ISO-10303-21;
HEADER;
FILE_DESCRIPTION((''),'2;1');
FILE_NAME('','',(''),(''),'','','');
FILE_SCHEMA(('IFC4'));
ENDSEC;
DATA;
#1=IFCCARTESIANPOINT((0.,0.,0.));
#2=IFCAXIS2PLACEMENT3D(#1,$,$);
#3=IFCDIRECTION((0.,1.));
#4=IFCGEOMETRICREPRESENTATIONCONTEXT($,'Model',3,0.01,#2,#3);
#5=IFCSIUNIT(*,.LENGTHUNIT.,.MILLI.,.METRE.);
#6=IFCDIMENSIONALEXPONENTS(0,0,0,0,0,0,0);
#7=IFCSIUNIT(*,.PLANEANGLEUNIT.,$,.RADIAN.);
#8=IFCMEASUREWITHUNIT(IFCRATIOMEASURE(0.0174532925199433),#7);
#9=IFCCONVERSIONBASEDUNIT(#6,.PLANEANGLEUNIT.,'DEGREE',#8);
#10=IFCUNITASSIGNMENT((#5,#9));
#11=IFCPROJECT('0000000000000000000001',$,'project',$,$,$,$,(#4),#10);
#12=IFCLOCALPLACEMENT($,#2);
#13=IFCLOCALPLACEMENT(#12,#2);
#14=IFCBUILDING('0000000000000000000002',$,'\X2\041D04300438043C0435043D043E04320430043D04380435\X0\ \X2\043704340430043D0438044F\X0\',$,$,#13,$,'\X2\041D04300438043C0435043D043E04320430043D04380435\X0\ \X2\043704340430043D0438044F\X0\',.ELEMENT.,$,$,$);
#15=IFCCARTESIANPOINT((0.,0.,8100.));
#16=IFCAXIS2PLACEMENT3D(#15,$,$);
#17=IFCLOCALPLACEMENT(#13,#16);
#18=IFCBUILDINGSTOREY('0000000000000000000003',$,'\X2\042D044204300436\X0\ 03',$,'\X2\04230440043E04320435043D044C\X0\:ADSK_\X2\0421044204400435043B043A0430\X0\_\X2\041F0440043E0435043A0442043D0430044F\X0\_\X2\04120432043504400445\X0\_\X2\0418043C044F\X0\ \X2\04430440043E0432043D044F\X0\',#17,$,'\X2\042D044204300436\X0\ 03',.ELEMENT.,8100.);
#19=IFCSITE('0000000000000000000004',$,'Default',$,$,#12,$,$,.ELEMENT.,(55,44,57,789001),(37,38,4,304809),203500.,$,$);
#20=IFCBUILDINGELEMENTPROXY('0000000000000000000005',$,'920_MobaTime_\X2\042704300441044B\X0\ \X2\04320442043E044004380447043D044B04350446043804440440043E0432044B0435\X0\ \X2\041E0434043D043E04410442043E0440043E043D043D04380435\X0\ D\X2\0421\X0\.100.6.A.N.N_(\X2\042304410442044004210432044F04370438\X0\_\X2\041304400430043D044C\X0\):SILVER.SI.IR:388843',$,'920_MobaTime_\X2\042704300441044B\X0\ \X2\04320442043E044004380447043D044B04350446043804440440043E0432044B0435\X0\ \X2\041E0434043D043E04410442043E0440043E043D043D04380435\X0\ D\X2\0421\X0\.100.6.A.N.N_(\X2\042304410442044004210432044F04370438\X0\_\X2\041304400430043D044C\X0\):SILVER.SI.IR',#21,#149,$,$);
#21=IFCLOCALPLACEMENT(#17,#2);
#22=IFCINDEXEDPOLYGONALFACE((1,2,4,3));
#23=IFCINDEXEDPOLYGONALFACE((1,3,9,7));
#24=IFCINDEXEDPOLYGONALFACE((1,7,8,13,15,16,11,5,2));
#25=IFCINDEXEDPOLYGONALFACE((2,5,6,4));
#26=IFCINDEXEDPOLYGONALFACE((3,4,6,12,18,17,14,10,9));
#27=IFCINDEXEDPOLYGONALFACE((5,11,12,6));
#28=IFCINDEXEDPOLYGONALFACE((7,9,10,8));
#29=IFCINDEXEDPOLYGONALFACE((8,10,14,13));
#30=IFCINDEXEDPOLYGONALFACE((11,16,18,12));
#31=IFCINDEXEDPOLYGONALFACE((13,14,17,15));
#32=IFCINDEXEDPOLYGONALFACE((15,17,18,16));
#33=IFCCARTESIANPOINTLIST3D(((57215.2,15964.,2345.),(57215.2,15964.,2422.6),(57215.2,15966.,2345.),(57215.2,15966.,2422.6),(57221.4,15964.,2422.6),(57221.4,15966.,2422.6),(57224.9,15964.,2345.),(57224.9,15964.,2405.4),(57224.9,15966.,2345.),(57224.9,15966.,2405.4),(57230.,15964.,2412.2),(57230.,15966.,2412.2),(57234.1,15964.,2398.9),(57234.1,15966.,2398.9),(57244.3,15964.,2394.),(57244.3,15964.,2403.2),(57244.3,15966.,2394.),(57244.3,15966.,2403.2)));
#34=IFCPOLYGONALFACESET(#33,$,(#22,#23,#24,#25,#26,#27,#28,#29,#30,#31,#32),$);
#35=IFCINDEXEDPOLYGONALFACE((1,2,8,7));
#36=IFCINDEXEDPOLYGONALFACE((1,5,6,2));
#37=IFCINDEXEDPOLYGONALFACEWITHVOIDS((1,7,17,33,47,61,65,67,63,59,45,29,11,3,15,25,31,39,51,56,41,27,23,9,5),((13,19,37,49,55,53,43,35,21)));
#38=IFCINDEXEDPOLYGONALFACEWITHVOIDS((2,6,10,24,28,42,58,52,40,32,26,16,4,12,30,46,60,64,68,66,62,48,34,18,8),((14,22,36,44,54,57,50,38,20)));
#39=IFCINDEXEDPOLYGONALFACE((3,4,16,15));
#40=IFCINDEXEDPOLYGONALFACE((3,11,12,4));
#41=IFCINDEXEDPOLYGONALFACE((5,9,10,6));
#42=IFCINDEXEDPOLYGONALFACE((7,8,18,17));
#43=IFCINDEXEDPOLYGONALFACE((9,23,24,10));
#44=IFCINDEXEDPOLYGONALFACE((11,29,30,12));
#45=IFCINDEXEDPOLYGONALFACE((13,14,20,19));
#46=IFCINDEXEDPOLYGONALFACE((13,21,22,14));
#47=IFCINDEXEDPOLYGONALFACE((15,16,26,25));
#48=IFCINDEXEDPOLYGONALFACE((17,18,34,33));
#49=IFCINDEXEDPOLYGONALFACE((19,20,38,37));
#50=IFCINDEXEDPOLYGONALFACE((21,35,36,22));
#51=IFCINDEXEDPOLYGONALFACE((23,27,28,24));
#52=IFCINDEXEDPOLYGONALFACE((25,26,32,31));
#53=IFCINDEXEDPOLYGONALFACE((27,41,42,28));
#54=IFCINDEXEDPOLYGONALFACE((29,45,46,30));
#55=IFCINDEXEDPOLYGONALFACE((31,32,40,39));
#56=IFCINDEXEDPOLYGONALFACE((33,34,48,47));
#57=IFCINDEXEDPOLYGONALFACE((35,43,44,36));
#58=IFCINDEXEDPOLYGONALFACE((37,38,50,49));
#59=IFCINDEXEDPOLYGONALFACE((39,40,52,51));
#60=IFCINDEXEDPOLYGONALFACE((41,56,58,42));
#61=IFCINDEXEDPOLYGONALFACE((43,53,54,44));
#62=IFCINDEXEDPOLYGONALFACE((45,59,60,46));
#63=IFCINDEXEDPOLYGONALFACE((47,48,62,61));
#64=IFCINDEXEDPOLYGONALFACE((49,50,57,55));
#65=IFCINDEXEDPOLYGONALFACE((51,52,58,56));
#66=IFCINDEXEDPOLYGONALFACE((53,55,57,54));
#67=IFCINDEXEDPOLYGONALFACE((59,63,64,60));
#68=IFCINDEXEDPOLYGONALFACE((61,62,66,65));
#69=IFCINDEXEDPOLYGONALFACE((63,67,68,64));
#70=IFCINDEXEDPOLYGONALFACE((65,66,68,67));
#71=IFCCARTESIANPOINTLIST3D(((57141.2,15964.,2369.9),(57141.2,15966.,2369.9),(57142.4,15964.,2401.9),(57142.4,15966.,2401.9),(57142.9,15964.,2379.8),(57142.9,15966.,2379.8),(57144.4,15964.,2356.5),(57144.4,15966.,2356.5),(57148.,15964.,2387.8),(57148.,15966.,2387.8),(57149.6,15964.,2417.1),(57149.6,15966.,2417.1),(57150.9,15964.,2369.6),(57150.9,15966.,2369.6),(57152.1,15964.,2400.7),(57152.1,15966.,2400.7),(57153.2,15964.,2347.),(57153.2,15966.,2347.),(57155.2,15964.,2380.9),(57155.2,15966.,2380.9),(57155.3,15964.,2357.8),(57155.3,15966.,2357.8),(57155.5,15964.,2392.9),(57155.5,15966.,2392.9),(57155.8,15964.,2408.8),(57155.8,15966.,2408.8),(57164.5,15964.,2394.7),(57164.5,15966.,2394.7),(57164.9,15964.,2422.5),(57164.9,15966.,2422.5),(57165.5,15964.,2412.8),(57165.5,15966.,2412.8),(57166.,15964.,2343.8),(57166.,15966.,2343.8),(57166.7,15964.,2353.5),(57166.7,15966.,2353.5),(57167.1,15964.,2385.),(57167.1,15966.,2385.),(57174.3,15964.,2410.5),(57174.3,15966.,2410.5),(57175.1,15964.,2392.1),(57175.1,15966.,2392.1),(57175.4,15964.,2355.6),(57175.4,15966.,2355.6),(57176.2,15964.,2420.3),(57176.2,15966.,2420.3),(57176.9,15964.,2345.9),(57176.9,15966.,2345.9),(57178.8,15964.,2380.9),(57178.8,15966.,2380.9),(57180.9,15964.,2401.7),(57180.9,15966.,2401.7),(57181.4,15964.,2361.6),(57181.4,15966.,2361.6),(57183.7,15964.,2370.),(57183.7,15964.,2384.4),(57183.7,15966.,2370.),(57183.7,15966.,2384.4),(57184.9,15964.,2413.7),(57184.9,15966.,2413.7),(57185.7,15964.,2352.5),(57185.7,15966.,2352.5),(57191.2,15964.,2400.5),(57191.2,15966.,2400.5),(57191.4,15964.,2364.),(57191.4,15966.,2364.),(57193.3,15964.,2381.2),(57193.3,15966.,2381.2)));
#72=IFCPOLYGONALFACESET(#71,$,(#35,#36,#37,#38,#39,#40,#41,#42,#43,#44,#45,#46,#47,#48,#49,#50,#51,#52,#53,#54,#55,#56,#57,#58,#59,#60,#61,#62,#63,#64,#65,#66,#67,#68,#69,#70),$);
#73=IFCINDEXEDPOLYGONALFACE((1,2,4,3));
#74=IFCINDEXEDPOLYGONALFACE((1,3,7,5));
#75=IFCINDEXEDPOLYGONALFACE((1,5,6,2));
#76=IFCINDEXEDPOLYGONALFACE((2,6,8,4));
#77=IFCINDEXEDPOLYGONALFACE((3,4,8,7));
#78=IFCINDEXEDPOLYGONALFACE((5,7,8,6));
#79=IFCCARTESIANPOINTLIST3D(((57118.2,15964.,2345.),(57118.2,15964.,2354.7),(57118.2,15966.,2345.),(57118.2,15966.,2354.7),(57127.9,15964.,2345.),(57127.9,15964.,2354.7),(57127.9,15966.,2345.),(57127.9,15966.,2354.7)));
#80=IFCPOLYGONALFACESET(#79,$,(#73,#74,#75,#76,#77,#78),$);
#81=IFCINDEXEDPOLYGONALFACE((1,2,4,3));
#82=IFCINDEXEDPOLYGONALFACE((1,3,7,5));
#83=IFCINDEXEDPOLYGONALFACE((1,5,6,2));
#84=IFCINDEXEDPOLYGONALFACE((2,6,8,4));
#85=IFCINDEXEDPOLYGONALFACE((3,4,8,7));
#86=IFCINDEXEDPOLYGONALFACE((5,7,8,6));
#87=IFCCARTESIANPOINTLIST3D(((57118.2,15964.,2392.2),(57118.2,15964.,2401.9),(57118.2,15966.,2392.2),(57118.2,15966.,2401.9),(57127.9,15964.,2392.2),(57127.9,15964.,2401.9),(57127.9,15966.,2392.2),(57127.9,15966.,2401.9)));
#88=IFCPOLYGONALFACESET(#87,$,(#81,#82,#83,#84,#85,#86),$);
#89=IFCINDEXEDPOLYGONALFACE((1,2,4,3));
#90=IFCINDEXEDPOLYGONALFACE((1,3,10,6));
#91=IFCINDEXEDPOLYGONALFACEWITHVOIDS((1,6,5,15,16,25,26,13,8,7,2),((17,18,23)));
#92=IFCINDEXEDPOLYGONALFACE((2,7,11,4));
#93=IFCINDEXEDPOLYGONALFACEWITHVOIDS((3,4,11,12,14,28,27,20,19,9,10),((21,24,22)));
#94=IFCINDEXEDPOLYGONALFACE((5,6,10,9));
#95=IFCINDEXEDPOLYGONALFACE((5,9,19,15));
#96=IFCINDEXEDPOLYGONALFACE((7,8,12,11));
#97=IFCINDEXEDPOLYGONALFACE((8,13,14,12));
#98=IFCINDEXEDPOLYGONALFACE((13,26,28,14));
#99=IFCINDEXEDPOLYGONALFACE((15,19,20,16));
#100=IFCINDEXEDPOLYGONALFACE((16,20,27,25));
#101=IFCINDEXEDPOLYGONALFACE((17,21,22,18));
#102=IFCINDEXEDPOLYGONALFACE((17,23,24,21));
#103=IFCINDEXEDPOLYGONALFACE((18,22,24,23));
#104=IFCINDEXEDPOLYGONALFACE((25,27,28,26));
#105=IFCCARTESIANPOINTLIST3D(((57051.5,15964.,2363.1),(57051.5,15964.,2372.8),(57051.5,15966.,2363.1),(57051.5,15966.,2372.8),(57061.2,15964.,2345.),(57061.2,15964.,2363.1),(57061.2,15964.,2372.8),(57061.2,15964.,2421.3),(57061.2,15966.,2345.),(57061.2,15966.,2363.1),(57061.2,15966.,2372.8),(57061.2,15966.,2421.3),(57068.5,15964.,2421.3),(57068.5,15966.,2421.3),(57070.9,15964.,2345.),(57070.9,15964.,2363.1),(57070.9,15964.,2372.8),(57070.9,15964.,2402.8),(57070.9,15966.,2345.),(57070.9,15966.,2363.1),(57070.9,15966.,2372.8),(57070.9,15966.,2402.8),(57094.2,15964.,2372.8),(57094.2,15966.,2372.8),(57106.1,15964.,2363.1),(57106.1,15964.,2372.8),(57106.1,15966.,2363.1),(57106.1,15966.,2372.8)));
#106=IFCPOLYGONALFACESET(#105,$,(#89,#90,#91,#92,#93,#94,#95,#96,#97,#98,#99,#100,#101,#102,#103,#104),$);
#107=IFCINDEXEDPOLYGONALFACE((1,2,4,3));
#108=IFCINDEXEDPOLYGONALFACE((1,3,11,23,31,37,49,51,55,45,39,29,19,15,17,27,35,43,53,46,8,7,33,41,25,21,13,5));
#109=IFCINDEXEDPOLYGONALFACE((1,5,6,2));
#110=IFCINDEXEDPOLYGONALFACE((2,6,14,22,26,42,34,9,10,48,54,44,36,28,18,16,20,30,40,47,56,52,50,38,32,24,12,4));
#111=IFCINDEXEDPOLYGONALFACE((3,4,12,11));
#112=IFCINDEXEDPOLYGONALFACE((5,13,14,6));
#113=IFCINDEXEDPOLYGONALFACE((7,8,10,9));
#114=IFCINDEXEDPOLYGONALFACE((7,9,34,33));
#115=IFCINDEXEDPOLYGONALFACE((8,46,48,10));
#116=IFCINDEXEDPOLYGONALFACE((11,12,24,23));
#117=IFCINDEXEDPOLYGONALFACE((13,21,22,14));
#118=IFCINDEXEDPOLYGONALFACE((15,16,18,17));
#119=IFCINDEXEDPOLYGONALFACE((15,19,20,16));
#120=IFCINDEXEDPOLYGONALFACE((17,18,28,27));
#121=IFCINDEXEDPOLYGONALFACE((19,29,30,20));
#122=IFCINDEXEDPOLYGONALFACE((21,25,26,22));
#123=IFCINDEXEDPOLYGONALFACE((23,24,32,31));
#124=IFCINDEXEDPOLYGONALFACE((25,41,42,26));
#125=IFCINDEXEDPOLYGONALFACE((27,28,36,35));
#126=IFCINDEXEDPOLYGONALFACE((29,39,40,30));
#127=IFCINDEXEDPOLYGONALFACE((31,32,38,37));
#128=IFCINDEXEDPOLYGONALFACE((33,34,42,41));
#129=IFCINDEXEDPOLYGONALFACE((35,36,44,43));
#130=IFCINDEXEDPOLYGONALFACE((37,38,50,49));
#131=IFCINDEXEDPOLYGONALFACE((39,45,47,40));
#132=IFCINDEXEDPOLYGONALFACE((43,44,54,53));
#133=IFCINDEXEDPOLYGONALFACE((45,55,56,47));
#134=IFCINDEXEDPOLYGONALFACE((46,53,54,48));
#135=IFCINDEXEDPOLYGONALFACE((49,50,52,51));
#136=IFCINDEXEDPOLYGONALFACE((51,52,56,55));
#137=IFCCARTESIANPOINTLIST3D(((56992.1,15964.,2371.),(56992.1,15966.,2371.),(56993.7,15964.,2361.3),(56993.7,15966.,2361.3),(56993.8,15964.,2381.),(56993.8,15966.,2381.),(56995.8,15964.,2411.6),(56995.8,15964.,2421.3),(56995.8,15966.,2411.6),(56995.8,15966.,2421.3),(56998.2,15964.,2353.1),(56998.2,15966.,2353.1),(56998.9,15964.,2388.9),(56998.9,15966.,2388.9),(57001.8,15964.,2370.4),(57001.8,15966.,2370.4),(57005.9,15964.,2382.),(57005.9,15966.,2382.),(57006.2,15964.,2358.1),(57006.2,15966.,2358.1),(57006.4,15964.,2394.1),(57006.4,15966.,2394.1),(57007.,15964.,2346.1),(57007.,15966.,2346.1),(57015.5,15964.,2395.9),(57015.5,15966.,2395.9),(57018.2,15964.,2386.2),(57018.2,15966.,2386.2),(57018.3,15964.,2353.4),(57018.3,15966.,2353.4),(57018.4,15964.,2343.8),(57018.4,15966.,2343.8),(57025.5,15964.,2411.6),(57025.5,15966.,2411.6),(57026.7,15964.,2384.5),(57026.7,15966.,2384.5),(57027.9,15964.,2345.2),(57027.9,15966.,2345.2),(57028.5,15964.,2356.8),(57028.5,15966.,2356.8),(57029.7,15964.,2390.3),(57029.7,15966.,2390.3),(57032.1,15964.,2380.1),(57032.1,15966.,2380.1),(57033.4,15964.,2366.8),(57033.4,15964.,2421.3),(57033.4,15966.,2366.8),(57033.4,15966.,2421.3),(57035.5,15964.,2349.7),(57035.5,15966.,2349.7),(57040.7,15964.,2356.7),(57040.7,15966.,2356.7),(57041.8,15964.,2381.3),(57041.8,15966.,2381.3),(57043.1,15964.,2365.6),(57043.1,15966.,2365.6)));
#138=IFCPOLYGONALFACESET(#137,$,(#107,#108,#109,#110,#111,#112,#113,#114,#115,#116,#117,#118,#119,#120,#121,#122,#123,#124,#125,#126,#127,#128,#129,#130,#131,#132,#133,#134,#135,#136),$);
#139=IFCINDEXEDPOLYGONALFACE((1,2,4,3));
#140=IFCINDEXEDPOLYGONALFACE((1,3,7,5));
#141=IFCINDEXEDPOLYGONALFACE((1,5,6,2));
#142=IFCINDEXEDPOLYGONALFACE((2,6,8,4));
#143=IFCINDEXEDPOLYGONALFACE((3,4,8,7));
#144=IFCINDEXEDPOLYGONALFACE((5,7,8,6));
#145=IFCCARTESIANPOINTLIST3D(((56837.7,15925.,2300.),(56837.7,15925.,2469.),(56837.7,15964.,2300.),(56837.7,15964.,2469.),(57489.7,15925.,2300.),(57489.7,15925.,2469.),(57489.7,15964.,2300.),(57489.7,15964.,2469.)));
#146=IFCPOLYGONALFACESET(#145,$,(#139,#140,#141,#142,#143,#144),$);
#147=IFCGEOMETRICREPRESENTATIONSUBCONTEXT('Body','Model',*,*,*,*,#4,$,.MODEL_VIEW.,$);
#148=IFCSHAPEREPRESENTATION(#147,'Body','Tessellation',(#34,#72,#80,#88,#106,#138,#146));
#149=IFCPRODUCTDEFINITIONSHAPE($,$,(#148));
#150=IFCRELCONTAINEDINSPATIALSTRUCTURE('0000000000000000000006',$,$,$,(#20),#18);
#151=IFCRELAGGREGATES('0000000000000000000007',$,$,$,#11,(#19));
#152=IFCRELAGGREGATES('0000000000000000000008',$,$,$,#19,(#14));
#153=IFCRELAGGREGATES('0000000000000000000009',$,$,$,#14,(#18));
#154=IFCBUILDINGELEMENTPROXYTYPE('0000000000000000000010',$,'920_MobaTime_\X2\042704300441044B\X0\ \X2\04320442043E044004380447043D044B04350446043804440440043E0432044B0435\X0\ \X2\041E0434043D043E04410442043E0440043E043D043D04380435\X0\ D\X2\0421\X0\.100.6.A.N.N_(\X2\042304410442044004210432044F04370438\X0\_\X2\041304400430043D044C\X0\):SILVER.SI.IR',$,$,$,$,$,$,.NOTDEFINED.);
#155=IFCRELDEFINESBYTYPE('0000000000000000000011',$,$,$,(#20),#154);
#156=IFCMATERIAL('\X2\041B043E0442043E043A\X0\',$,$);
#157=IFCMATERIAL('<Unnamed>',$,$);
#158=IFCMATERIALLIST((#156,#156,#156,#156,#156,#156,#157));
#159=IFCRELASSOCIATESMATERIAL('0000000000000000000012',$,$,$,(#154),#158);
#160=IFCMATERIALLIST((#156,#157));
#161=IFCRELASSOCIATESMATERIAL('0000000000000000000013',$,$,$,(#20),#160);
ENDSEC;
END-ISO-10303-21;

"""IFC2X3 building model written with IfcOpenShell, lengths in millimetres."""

from ifc_helpers import new_model, entity, si_unit, converted_unit, direction, frame, origin, origin_2d_with_axis, place, context, subcontext, project, spatial, polyline, rectangle, outline, extrude, source, transform, mapped, material, material_list, type_object, type_shapes, element, save


model = new_model("IFC2X3")

# Units and contexts
model_context = context("Model", 3, precision=0.01, world=origin(), true_north=direction((0.0, 1.0)))
body_context = subcontext(model_context, "Body", "Model", "MODEL_VIEW")
ifc_project = project(units=[si_unit("LENGTHUNIT", "METRE", prefix="MILLI"), converted_unit("PLANEANGLEUNIT", "DEGREE", entity("IfcRatioMeasure", 0.0174532925199433), si_unit("PLANEANGLEUNIT", "RADIAN"), dimensions=[0, 0, 0, 0, 0, 0, 0])], contexts=[model_context])

# Site, building, storey
site_placement = place(None, origin())
site = spatial("IfcSite", under=ifc_project, at=site_placement, Name="Default", CompositionType="ELEMENT", RefLatitude=(55, 44, 57, 789001), RefLongitude=(37, 38, 4, 304809), RefElevation=203500.0)
building_placement = place(site_placement, origin())
building = spatial("IfcBuilding", under=site, at=building_placement, Name="Наименование здания", LongName="Наименование здания", CompositionType="ELEMENT")
storey_placement = place(building_placement, frame((0.0, 0.0, 8100.0)))
storey = spatial("IfcBuildingStorey", under=building, at=storey_placement, Name="Этаж 03", ObjectType="Уровень:ADSK_Стрелка_Проектная_Вверх_Имя уровня", LongName="Этаж 03", CompositionType="ELEMENT", Elevation=8100.0)

# Building element proxy
ifc_material_1 = material(Name="Лоток")
ifc_material_2 = material(Name="<Unnamed>")
ifc_material_list_1 = material_list([ifc_material_1, ifc_material_1, ifc_material_1, ifc_material_1, ifc_material_1, ifc_material_1, ifc_material_2])
building_element_proxy_type = type_object("IfcBuildingElementProxyType", Name="920_MobaTime_Часы вторичныецифровые Односторонние DС.100.6.A.N.N_(УстрСвязи_Грань):SILVER.SI.IR", PredefinedType="NOTDEFINED", material=ifc_material_list_1)
shared_shape = source(origin(), body_context, "Body", "SweptSolid", [
    extrude(outline(polyline([(-49.3, -13.1), (28.2, -13.1), (28.2, -6.8), (17.9, 1.8), (8.8, 16.0), (-0.3, 16.0), (4.6, 5.8), (11.1, -3.4), (-49.3, -3.4), (-49.3, -13.1)])), frame((-64.6, 9.8, 39.0), z_axis=(0.0, 0.0, 1.0), x_axis=(0.0, 1.0, 0.0)), (0.0, 0.0, 1.0), 2.0),
    extrude(outline(polyline([(2.2, -27.6), (19.0, -27.6), (30.5, -16.1), (33.3, -4.9), (31.0, 5.8), (21.8, 17.2), (5.2, 27.3), (-11.1, 33.0), (-24.0, 32.7), (-33.6, 27.6), (-40.3, 18.6), (-42.8, 5.7), (-38.0, -6.3), (-27.2, -14.9), (-17.5, -17.7), (-8.2, -16.4), (-0.3, -11.9), (5.1, -4.5), (7.3, 6.2), (4.0, 17.2), (18.4, 7.3), (23.6, -2.4), (22.0, -11.4), (14.2, -18.4), (5.3, -18.3), (2.2, -27.6)]), holes=[polyline([(-9.0, 23.3), (-1.3, 14.3), (-2.5, 2.0), (-11.4, -7.0), (-23.4, -6.0), (-32.2, 2.9), (-31.2, 15.1), (-25.6, 22.1), (-17.5, 24.9), (-9.0, 23.3)])]), frame((-2.7, 3.6, 39.0), z_axis=(0.0, 0.0, 1.0), x_axis=(-0.427649, 0.903945, 0.0)), (0.0, 0.0, 1.0), 2.0),
    extrude(rectangle(XDim=9.7, YDim=9.7, at=origin_2d_with_axis()), frame((40.6, -34.7, 39.0)), (0.0, 0.0, 1.0), 2.0),
    extrude(rectangle(XDim=9.7, YDim=9.7, at=origin_2d_with_axis()), frame((40.6, 12.6, 39.0)), (0.0, 0.0, 1.0), 2.0),
    extrude(outline(polyline([(-0.9, -28.1), (8.8, -28.1), (8.8, -9.9), (18.5, -9.9), (18.5, -0.2), (8.8, -0.2), (8.8, 48.3), (1.5, 48.3), (-36.0, -0.2), (-36.0, -9.9), (-0.9, -9.9), (-0.9, -28.1)]), holes=[polyline([(-0.9, -0.2), (-24.1, -0.2), (-0.9, 29.7), (-0.9, -0.2)])]), frame((93.6, -11.4, 39.0)), (0.0, 0.0, 1.0), 2.0),
    extrude(outline(polyline([(3.3, -28.3), (12.5, -28.3), (20.5, -25.0), (26.8, -18.9), (30.7, -10.0), (31.4, 1.6), (26.9, 11.8), (20.1, 18.4), (11.1, 22.3), (1.0, 23.3), (-7.9, 20.4), (-14.9, 14.5), (-18.9, 6.2), (-17.1, -9.0), (-36.7, 0.5), (-29.1, 29.2), (-38.5, 31.7), (-48.1, -4.6), (-11.6, -23.1), (-8.0, -14.0), (-10.8, -7.6), (-10.2, 1.1), (-3.0, 11.8), (9.2, 12.8), (20.0, 5.5), (21.4, -7.5), (15.5, -16.4), (4.6, -18.6), (3.3, -28.3)])), frame((147.1, -8.5, 39.0), z_axis=(0.0, 0.0, 1.0), x_axis=(0.256974, -0.966418, 0.0)), (0.0, 0.0, 1.0), 2.0),
    extrude(rectangle(XDim=652.0, YDim=169.0, at=origin_2d_with_axis()), frame((0.0, 0.0, 0.0), z_axis=(0.0, 0.0, 1.0), x_axis=(-1.0, 0.0, 0.0)), (0.0, 0.0, 1.0), 39.0),
])
type_shapes(building_element_proxy_type, [shared_shape])
ifc_material_list_2 = material_list([ifc_material_1, ifc_material_2])
for number, where, z_axis, x_axis, name in (
    (1, (57163.7, 15925.0, 2384.5), (0.0, 1.0, 0.0), (-1.0, 0.0, 0.0), "920_MobaTime_Часы вторичныецифровые Односторонние DС.100.6.A.N.N_(УстрСвязи_Грань):SILVER.SI.IR:388843"),
):
    element("IfcBuildingElementProxy", number, at=place(storey_placement, frame(where, z_axis=z_axis, x_axis=x_axis)), inside=storey, type_object=building_element_proxy_type, material=ifc_material_list_2, Name=name, ObjectType="920_MobaTime_Часы вторичныецифровые Односторонние DС.100.6.A.N.N_(УстрСвязи_Грань):SILVER.SI.IR", context=body_context, shape_type="MappedRepresentation", body=[
        mapped(shared_shape, transform((0.0, 0.0, 0.0), scale=1.0)),
    ])

save(model, "model.ifc")
